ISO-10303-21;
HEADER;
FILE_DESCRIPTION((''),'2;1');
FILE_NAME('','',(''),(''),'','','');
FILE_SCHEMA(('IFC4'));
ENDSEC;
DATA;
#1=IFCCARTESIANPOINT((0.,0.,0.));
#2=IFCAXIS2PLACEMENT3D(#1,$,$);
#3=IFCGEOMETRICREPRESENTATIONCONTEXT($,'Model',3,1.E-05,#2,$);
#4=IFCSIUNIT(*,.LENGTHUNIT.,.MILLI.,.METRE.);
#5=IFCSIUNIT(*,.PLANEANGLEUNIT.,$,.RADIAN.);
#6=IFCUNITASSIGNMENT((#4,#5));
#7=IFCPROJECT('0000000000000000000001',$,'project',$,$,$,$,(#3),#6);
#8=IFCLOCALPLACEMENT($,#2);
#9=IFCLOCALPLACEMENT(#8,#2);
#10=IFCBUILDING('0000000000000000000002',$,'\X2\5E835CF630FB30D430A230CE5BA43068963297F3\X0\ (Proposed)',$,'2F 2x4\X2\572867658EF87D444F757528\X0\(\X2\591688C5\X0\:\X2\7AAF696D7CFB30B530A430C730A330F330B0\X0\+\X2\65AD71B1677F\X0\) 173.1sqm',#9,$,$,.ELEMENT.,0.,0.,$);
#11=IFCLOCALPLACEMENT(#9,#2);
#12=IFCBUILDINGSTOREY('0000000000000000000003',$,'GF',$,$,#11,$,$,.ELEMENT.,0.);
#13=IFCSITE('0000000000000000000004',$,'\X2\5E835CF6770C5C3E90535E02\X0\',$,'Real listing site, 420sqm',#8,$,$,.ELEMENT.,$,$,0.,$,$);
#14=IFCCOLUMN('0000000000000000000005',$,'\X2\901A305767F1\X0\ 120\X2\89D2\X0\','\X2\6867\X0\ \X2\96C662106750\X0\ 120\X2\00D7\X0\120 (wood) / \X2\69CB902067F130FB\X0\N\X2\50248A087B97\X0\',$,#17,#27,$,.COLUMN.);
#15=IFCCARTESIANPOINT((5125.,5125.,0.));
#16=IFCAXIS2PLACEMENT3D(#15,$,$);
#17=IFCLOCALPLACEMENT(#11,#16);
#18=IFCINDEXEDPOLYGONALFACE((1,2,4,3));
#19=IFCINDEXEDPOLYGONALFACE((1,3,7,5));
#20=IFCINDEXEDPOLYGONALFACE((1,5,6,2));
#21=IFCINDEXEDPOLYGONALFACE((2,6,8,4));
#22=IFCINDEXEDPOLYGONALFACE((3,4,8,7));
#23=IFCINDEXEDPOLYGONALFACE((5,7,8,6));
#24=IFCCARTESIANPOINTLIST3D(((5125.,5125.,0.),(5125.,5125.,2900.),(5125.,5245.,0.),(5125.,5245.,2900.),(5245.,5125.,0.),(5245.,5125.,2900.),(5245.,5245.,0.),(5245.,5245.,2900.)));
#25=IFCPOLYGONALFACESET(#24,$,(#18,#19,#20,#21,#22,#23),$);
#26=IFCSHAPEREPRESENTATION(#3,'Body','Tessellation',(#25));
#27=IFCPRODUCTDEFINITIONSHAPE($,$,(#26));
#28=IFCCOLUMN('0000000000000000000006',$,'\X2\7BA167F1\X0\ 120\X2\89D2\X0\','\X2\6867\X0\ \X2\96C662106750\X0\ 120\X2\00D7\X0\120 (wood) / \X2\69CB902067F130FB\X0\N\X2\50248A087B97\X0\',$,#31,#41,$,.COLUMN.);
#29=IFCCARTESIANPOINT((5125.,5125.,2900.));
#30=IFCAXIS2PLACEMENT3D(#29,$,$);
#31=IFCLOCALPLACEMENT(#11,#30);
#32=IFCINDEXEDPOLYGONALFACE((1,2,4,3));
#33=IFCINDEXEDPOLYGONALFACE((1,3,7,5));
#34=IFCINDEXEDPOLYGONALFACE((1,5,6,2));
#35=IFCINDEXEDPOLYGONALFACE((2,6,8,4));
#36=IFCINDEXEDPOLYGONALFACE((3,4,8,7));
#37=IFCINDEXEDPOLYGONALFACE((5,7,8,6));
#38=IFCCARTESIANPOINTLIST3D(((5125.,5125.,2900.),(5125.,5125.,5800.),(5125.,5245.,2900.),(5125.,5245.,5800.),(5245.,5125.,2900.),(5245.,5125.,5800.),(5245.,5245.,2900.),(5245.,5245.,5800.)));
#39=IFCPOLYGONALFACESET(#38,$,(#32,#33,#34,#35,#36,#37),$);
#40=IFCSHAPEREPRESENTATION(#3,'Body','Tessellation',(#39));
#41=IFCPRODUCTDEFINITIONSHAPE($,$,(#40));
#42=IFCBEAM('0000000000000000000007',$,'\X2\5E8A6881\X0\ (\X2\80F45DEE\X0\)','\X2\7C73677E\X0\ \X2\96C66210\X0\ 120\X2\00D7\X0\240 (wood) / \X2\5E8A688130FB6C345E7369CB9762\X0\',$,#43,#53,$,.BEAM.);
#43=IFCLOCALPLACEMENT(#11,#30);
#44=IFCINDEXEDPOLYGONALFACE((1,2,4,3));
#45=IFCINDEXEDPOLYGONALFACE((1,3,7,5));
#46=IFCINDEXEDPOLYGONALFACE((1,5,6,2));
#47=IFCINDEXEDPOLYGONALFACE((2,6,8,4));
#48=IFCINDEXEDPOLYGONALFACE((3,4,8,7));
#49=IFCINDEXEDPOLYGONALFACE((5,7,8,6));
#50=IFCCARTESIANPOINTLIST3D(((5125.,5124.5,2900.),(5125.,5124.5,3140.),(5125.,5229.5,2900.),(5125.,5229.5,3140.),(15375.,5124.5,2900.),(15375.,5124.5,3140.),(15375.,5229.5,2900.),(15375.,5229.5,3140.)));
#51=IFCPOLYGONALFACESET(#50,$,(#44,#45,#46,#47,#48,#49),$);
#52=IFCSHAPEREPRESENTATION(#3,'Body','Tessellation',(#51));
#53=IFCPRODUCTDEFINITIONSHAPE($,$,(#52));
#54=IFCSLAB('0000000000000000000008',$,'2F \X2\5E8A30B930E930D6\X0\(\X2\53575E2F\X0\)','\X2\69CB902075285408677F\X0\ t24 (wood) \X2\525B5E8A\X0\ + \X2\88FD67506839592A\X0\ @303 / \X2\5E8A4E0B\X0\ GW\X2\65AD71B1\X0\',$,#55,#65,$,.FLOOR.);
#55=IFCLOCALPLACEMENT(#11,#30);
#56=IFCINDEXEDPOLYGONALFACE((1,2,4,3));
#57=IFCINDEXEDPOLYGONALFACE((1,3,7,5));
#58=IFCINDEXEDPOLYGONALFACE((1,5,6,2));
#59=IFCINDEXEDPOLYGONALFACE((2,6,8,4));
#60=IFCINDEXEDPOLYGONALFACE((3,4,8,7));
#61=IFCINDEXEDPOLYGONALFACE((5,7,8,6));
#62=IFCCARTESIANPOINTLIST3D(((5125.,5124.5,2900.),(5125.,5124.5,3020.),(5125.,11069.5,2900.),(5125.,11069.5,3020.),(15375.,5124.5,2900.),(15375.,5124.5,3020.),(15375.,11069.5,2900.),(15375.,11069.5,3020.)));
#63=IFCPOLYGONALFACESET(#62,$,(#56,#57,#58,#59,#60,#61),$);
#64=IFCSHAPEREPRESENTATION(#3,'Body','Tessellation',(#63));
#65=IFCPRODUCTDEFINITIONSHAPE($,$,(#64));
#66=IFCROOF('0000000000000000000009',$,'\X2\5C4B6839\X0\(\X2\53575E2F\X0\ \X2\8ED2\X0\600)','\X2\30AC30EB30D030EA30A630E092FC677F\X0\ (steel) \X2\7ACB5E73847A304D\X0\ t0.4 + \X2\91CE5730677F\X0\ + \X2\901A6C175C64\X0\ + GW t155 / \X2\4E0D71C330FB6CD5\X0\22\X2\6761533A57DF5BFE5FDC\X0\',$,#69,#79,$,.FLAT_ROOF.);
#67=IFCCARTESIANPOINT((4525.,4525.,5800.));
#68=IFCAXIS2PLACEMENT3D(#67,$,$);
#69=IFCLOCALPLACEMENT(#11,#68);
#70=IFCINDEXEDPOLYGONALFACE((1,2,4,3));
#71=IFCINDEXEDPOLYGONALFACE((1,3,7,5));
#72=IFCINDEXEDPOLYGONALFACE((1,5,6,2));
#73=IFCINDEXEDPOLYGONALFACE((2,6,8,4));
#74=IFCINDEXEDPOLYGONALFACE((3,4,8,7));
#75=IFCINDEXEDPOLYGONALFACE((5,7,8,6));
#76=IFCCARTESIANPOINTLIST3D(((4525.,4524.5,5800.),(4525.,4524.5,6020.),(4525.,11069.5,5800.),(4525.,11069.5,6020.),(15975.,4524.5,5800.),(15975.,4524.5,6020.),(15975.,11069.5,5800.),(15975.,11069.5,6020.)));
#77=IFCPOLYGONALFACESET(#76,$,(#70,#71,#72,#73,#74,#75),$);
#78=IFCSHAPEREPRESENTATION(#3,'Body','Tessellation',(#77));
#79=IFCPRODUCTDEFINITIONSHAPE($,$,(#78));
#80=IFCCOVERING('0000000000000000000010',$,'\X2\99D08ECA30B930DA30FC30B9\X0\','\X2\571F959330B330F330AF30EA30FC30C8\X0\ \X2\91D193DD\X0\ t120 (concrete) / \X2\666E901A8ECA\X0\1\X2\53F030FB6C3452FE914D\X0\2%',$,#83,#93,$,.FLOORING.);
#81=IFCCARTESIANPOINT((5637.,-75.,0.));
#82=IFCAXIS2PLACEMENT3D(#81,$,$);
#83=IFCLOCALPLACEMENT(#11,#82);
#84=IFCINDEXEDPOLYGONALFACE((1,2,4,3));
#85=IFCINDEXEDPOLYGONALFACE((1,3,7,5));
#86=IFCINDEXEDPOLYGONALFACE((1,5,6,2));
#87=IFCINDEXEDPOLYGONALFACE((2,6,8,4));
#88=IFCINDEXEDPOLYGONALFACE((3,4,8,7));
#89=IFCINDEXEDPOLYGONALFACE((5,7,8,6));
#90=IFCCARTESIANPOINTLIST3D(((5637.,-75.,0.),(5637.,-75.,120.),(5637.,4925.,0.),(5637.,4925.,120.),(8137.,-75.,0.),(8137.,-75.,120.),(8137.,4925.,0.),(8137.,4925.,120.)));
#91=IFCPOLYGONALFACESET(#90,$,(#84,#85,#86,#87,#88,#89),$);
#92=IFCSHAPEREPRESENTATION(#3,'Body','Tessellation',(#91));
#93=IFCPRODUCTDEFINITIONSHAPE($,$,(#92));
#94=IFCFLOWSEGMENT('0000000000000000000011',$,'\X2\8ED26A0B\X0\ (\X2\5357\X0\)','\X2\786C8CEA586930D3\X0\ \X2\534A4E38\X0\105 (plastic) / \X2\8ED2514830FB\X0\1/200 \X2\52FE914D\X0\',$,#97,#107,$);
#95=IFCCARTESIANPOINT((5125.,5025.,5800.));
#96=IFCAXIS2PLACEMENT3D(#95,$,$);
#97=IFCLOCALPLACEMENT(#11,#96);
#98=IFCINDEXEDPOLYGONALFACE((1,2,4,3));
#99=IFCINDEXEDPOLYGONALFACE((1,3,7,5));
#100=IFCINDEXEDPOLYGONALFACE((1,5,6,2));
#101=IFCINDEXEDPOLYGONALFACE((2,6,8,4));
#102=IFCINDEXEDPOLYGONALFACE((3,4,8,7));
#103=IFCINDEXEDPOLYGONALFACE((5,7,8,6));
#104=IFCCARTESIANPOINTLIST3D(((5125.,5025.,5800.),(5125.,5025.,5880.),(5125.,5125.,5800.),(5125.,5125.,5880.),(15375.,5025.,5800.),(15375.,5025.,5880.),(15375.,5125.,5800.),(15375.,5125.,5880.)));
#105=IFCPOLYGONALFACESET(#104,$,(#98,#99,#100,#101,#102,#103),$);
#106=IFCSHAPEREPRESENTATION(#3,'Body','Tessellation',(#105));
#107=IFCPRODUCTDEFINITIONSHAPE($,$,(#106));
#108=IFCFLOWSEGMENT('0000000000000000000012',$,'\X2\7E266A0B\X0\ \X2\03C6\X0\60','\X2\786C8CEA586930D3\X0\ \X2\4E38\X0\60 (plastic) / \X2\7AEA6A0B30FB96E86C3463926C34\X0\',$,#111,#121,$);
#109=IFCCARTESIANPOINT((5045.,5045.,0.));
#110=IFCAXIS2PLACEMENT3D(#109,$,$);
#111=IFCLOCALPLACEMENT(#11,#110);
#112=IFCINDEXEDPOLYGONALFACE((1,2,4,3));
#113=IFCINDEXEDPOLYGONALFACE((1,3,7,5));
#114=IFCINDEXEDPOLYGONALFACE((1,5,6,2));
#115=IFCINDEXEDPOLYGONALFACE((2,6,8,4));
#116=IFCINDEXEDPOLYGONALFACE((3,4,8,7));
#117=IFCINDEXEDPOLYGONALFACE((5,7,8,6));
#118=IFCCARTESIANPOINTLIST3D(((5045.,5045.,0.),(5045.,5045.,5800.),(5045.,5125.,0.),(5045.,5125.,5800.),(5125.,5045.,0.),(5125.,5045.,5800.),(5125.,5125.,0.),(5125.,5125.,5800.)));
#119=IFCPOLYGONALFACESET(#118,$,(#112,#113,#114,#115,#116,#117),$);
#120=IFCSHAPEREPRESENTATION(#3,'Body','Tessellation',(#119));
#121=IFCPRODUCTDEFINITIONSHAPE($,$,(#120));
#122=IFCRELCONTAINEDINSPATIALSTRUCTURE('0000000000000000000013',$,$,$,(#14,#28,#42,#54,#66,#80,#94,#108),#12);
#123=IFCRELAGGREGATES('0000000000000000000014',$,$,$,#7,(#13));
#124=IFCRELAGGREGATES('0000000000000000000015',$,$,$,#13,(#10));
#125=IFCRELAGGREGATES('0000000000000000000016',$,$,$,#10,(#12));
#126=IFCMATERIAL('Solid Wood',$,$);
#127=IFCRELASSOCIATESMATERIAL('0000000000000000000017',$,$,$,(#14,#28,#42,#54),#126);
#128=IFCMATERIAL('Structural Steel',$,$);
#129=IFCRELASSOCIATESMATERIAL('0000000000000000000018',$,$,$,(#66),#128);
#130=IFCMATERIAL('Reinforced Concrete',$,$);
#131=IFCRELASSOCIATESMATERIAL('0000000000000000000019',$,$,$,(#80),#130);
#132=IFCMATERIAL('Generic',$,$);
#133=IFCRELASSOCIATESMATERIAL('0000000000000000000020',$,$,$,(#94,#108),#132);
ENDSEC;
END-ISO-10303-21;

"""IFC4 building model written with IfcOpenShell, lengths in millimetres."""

from ifc_helpers import new_model, si_unit, frame, frame_2d, origin, place, context, project, spatial, rectangle, extrude, material, element, save


model = new_model("IFC4")

# Units and contexts
model_context = context("Model", 3, precision=1e-05, world=origin())
ifc_project = project(units=[si_unit("LENGTHUNIT", "METRE", prefix="MILLI"), si_unit("PLANEANGLEUNIT", "RADIAN")], contexts=[model_context])

# Site, building, storey
site_placement = place(None, origin())
site = spatial("IfcSite", under=ifc_project, at=site_placement, Name="広島県尾道市", ObjectType="Real listing site, 420sqm", CompositionType="ELEMENT", RefElevation=0.0)
building_placement = place(site_placement, origin())
building = spatial("IfcBuilding", under=site, at=building_placement, Name="広島・ピアノ室と防音 (Proposed)", ObjectType="2F 2x4在来軸組併用(外装:窯業系サイディング+断熱板) 173.1sqm", CompositionType="ELEMENT", ElevationOfRefHeight=0.0, ElevationOfTerrain=0.0)
storey_placement = place(building_placement, origin())
storey = spatial("IfcBuildingStorey", under=building, at=storey_placement, Name="GF", CompositionType="ELEMENT", Elevation=0.0)

# Columns
ifc_material_1 = material(Name="Solid Wood")
column_1_placement = place(storey_placement, frame((5125.0, 5125.0, 0.0)))
element("IfcColumn", 1, at=column_1_placement, inside=storey, material=ifc_material_1, Name="通し柱 120角", Description="桧 集成材 120×120 (wood) / 構造柱・N値計算", PredefinedType="COLUMN", context=model_context, shape_type="SweptSolid", body=[
    extrude(rectangle(XDim=120.0, YDim=120.0, at=frame_2d((60.0, 60.0))), frame((5125.0, 5125.0, 0.0)), (0.0, 0.0, 1.0), 2900.0),
])
column_2_placement = place(storey_placement, frame((5125.0, 5125.0, 2900.0)))
element("IfcColumn", 2, at=column_2_placement, inside=storey, material=ifc_material_1, Name="管柱 120角", Description="桧 集成材 120×120 (wood) / 構造柱・N値計算", PredefinedType="COLUMN", context=model_context, shape_type="SweptSolid", body=[
    extrude(rectangle(XDim=120.0, YDim=120.0, at=frame_2d((60.0, 60.0))), frame((5125.0, 5125.0, 2900.0)), (0.0, 0.0, 1.0), 2900.0),
])

# Beam
beam_1_placement = place(storey_placement, frame((5125.0, 5125.0, 2900.0)))
element("IfcBeam", 3, at=beam_1_placement, inside=storey, material=ifc_material_1, Name="床梁 (胴差)", Description="米松 集成 120×240 (wood) / 床梁・水平構面", PredefinedType="BEAM", context=model_context, shape_type="SweptSolid", body=[
    extrude(rectangle(XDim=10250.0, YDim=105.0, at=frame_2d((5125.0, 52.0))), frame((5125.0, 5125.0, 2900.0)), (0.0, 0.0, 1.0), 240.0),
])

# Slab
ifc_material_2 = material(Name="Reinforced Concrete")
slab_1_placement = place(storey_placement, frame((5125.0, 5125.0, 2900.0)))
element("IfcSlab", 4, at=slab_1_placement, inside=storey, material=ifc_material_1, Name="2F 床スラブ(南帯)", Description="構造用合板 t24 (wood) 剛床 + 製材根太 @303 / 床下 GW断熱", PredefinedType="FLOOR", context=model_context, shape_type="SweptSolid", body=[
    extrude(rectangle(XDim=10250.0, YDim=5945.0, at=frame_2d((5125.0, 2972.0))), frame((5125.0, 5125.0, 2900.0)), (0.0, 0.0, 1.0), 120.0),
])

# Roof
ifc_material_3 = material(Name="Structural Steel")
for number, where, name in (
    (5, (4525.0, 4525.0, 5800.0), "屋根(南帯 軒600)"),
):
    element("IfcRoof", number, at=place(storey_placement, frame(where)), inside=storey, material=ifc_material_3, Name=name, Description="ガルバリウム鋼板 (steel) 立平葺き t0.4 + 野地板 + 通気層 + GW t155 / 不燃・法22条区域対応", PredefinedType="FLAT_ROOF", context=model_context, shape_type="SweptSolid", body=[
        extrude(rectangle(XDim=11450.0, YDim=6545.0, at=frame_2d((5725.0, 3272.0))), frame((4525.0, 4525.0, 5800.0)), (0.0, 0.0, 1.0), 220.0),
    ])

# Covering
covering_placement = place(storey_placement, frame((5637.0, -75.0, 0.0)))
element("IfcCovering", 6, at=covering_placement, inside=storey, material=ifc_material_2, Name="駐車スペース", Description="土間コンクリート 金鏝 t120 (concrete) / 普通車1台・水勾配2%", PredefinedType="FLOORING", context=model_context, shape_type="SweptSolid", body=[
    extrude(rectangle(XDim=2500.0, YDim=5000.0, at=frame_2d((1250.0, 2500.0))), frame((5637.0, -75.0, 0.0)), (0.0, 0.0, 1.0), 120.0),
])

# Flow segments
ifc_material_4 = material(Name="Generic")
flow_segment_1_placement = place(storey_placement, frame((5125.0, 5025.0, 5800.0)))
element("IfcFlowSegment", 7, at=flow_segment_1_placement, inside=storey, material=ifc_material_4, Name="軒樋 (南)", Description="硬質塩ビ 半丸105 (plastic) / 軒先・1/200 勾配", context=model_context, shape_type="SweptSolid", body=[
    extrude(rectangle(XDim=10250.0, YDim=100.0, at=frame_2d((5125.0, 50.0))), frame((5125.0, 5025.0, 5800.0)), (0.0, 0.0, 1.0), 80.0),
])
flow_segment_2_placement = place(storey_placement, frame((5045.0, 5045.0, 0.0)))
element("IfcFlowSegment", 8, at=flow_segment_2_placement, inside=storey, material=ifc_material_4, Name="縦樋 φ60", Description="硬質塩ビ 丸60 (plastic) / 竪樋・雨水排水", context=model_context, shape_type="SweptSolid", body=[
    extrude(rectangle(XDim=80.0, YDim=80.0, at=frame_2d((40.0, 40.0))), frame((5045.0, 5045.0, 0.0)), (0.0, 0.0, 1.0), 5800.0),
])

save(model, "model.ifc")
